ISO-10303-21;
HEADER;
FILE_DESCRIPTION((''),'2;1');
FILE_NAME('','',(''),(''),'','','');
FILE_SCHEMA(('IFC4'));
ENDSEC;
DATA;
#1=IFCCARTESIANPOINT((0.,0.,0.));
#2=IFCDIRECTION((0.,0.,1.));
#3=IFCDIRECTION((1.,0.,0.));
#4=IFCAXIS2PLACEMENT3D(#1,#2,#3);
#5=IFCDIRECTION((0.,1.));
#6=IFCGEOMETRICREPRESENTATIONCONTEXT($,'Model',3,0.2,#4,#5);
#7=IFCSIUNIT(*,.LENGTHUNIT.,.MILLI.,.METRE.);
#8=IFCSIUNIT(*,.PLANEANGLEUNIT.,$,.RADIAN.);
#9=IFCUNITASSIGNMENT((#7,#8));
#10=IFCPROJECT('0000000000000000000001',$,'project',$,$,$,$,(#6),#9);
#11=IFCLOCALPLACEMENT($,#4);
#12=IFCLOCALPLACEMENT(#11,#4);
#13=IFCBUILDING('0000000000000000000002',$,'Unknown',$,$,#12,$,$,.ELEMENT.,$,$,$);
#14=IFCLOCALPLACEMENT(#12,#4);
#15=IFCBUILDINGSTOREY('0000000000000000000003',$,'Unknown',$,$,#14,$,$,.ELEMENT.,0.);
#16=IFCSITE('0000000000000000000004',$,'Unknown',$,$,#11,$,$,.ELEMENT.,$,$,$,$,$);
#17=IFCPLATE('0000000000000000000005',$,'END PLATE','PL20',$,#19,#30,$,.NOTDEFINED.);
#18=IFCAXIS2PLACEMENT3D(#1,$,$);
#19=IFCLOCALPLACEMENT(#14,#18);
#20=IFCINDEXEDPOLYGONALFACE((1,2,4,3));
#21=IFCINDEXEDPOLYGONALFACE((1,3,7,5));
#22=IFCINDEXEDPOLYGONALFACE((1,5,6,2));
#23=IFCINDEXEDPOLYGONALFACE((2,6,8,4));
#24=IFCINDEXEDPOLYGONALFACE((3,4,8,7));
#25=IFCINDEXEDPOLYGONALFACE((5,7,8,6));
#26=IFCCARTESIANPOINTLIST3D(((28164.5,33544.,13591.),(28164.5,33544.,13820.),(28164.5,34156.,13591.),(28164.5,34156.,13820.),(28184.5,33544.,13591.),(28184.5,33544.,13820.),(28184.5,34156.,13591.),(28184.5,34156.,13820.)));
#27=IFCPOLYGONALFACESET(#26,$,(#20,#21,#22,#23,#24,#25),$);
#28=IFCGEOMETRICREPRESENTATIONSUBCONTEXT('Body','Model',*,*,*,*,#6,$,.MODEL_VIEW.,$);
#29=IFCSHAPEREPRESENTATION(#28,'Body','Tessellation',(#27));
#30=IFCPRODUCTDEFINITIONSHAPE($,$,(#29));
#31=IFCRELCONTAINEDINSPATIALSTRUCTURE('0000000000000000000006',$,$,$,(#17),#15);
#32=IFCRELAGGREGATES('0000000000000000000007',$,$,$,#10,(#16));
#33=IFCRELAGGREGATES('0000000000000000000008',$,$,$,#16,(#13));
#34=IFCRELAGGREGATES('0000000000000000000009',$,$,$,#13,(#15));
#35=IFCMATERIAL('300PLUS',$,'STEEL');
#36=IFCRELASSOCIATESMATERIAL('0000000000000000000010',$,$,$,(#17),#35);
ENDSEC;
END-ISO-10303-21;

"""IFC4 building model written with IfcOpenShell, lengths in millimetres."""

from ifc_helpers import new_model, si_unit, direction, frame, origin_with_axes, place, context, subcontext, project, spatial, line, indexed_curve, outline, extrude, material, element, save


model = new_model("IFC4")

# Units and contexts
model_context = context("Model", 3, precision=0.2, world=origin_with_axes(), true_north=direction((0.0, 1.0)))
body_context = subcontext(model_context, "Body", "Model", "MODEL_VIEW")
ifc_project = project(units=[si_unit("LENGTHUNIT", "METRE", prefix="MILLI"), si_unit("PLANEANGLEUNIT", "RADIAN")], contexts=[model_context])

# Site, building, storey
site_placement = place(None, origin_with_axes())
site = spatial("IfcSite", under=ifc_project, at=site_placement, Name="Unknown", CompositionType="ELEMENT")
building_placement = place(site_placement, origin_with_axes())
building = spatial("IfcBuilding", under=site, at=building_placement, Name="Unknown", CompositionType="ELEMENT")
storey_placement = place(building_placement, origin_with_axes())
storey = spatial("IfcBuildingStorey", under=building, at=storey_placement, Name="Unknown", CompositionType="ELEMENT", Elevation=0.0)

# Shared definitions
ifc_material_1 = material(Name="300PLUS", Category="STEEL")

# Plate
plate_1_placement = place(storey_placement, frame((28174.5, 33544.0, 13820.0), z_axis=(1.0, 0.0, 0.0), x_axis=(0.0, 0.0, -1.0)))
element("IfcPlate", 1, at=plate_1_placement, inside=storey, material=ifc_material_1, Name="END PLATE", Description="PL20", PredefinedType="NOTDEFINED", context=body_context, shape_type="SolidModel", body=[
    extrude(outline(indexed_curve([(0.0, 0.0), (229.0, 0.0), (229.0, 612.0), (0.0, 612.0)], segments=[line(1, 2, 3, 4, 1)])), frame((0.0, 0.0, 10.0), z_axis=(0.0, 0.0, 1.0), x_axis=(1.0, 0.0, 0.0)), (0.0, 0.0, -1.0), 20.0),
])

save(model, "model.ifc")
